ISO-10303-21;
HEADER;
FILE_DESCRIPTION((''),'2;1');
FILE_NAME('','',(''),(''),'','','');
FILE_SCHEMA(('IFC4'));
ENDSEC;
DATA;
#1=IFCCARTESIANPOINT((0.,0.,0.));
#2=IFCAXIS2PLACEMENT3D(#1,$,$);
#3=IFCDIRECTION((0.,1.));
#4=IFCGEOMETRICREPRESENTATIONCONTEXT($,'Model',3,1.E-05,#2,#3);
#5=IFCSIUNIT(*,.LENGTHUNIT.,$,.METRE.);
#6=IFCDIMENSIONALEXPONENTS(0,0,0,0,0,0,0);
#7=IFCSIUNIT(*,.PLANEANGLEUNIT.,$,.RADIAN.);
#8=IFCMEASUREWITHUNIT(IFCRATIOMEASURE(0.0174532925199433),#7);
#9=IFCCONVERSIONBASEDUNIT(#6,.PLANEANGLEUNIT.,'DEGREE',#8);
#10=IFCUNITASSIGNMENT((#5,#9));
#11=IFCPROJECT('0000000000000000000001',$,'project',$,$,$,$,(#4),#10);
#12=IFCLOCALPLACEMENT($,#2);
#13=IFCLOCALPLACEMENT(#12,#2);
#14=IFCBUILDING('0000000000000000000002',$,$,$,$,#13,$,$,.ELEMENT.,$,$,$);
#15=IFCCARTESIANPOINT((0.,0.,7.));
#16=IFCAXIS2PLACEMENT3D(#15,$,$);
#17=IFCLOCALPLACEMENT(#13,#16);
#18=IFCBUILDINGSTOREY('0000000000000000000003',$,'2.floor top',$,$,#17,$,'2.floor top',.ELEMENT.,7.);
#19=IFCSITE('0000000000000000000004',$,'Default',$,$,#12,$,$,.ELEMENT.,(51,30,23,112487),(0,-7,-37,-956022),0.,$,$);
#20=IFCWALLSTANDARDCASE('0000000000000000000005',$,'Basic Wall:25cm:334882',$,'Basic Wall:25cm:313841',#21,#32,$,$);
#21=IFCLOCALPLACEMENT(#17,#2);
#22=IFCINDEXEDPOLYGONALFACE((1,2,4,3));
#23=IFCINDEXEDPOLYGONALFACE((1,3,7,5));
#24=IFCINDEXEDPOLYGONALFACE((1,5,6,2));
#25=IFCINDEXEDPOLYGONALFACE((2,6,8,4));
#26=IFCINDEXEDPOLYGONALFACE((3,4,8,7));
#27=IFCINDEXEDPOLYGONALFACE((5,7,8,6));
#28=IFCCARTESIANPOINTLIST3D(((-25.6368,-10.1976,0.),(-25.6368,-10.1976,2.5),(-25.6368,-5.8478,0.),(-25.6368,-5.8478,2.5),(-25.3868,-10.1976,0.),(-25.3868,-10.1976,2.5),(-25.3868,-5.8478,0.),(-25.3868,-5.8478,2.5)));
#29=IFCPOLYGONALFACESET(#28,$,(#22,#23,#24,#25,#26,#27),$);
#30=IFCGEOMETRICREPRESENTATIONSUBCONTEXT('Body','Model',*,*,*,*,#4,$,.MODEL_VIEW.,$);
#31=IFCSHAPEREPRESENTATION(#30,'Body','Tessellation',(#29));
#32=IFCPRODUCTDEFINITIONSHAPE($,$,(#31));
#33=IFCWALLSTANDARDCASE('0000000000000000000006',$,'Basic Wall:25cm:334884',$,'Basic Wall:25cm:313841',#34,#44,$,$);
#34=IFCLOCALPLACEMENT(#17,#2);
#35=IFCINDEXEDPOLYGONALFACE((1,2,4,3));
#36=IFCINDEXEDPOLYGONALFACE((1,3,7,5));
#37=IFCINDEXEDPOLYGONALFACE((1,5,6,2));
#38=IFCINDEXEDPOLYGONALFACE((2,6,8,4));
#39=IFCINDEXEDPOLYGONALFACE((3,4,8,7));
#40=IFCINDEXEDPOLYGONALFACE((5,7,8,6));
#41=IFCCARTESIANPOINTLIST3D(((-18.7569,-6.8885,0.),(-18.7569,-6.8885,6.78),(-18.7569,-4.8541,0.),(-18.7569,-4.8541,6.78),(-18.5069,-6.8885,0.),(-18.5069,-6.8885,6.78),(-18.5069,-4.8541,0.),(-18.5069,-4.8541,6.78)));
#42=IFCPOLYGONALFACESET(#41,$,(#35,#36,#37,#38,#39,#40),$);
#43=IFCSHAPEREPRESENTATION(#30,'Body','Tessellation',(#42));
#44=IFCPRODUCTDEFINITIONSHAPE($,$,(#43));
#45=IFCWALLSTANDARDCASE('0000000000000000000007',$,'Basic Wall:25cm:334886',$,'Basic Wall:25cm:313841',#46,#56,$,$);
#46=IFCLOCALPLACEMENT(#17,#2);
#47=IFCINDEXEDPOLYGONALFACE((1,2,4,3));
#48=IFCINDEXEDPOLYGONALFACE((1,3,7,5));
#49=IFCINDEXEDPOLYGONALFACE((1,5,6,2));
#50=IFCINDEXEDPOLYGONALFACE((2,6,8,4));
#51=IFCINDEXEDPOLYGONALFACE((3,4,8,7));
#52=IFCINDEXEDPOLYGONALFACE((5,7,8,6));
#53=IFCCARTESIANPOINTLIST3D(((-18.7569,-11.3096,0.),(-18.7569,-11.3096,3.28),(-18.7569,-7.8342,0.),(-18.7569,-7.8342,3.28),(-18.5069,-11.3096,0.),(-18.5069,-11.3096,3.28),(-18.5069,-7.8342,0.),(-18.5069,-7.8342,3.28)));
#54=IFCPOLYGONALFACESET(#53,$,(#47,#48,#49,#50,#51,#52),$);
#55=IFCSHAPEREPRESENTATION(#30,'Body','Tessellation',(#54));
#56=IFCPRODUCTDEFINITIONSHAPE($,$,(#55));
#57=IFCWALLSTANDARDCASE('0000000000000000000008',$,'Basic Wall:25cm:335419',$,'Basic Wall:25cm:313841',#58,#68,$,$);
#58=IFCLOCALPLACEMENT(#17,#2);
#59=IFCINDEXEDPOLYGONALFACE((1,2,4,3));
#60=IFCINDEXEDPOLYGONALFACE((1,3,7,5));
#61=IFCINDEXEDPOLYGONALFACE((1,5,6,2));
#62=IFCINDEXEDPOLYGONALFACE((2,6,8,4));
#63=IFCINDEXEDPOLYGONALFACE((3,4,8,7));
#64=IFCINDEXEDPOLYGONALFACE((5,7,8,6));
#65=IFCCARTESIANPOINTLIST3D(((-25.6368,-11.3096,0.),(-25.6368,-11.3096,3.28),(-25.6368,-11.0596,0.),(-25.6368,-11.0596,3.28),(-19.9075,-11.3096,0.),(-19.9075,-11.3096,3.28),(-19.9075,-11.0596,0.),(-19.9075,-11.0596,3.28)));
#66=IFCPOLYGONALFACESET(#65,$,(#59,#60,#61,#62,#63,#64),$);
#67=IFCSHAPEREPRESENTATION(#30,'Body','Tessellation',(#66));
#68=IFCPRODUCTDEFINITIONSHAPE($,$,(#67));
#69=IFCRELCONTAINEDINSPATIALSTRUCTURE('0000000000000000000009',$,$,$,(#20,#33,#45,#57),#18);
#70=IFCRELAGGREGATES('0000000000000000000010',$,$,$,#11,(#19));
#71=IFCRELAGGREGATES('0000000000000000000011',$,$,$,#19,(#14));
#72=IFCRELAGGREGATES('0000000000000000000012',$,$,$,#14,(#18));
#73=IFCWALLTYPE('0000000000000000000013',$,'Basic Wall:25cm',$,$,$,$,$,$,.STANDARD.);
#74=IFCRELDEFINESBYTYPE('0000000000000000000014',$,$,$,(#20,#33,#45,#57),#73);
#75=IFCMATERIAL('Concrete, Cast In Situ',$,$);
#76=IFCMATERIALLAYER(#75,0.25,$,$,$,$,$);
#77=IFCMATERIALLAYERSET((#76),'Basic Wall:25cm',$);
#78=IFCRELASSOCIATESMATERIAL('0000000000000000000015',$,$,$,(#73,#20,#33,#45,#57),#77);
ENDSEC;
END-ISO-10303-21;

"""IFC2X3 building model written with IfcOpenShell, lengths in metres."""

from ifc_helpers import new_model, entity, si_unit, converted_unit, direction, frame, frame_2d, origin, place, context, subcontext, project, spatial, rectangle, extrude, material, layer, layer_set, layer_usage, type_object, element, save


model = new_model("IFC2X3")

# Units and contexts
model_context = context("Model", 3, precision=1e-05, world=origin(), true_north=direction((0.0, 1.0)))
body_context = subcontext(model_context, "Body", "Model", "MODEL_VIEW")
ifc_project = project(units=[si_unit("LENGTHUNIT", "METRE"), converted_unit("PLANEANGLEUNIT", "DEGREE", entity("IfcRatioMeasure", 0.0174532925199433), si_unit("PLANEANGLEUNIT", "RADIAN"), dimensions=[0, 0, 0, 0, 0, 0, 0])], contexts=[model_context])

# Site, building, storey
site_placement = place(None, origin())
site = spatial("IfcSite", under=ifc_project, at=site_placement, Name="Default", CompositionType="ELEMENT", RefLatitude=(51, 30, 23, 112487), RefLongitude=(0, -7, -37, -956022), RefElevation=0.0)
building_placement = place(site_placement, origin())
building = spatial("IfcBuilding", under=site, at=building_placement, CompositionType="ELEMENT")
storey_placement = place(building_placement, frame((0.0, 0.0, 7.0)))
storey = spatial("IfcBuildingStorey", under=building, at=storey_placement, Name="2.floor top", LongName="2.floor top", CompositionType="ELEMENT", Elevation=7.0)

# Shared definitions
ifc_material = material(Name="Concrete, Cast In Situ")
ifc_layer = layer(ifc_material, 0.25)
ifc_layer_set = layer_set([ifc_layer], Name="Basic Wall:25cm")
wall_type = type_object("IfcWallType", Name="Basic Wall:25cm", PredefinedType="STANDARD", material=ifc_layer_set)

# Walls
ifc_layer_usage_1 = layer_usage(ifc_layer_set, "AXIS2", "NEGATIVE", 0.125)
wall_1_placement = place(storey_placement, frame((-25.5118, -5.8478, 0.0), z_axis=(0.0, 0.0, 1.0), x_axis=(0.0, -1.0, 0.0)))
element("IfcWallStandardCase", 1, at=wall_1_placement, inside=storey, type_object=wall_type, material=ifc_layer_usage_1, Name="Basic Wall:25cm:334882", ObjectType="Basic Wall:25cm:313841", context=body_context, shape_type="SweptSolid", body=[
    extrude(rectangle(XDim=4.3498, YDim=0.25, at=frame_2d((2.1749, 0.0), x_axis=(-1.0, 0.0))), origin(), (0.0, 0.0, 1.0), 2.5),
])
ifc_layer_usage_2 = layer_usage(ifc_layer_set, "AXIS2", "NEGATIVE", 0.125)
wall_2_placement = place(storey_placement, frame((-18.6319, -6.8885, 0.0), z_axis=(0.0, 0.0, 1.0), x_axis=(0.0, 1.0, 0.0)))
element("IfcWallStandardCase", 2, at=wall_2_placement, inside=storey, type_object=wall_type, material=ifc_layer_usage_2, Name="Basic Wall:25cm:334884", ObjectType="Basic Wall:25cm:313841", context=body_context, shape_type="SweptSolid", body=[
    extrude(rectangle(XDim=2.0344, YDim=0.25, at=frame_2d((1.0172, 0.0), x_axis=(-1.0, 0.0))), origin(), (0.0, 0.0, 1.0), 6.78),
])
ifc_layer_usage_3 = layer_usage(ifc_layer_set, "AXIS2", "POSITIVE", -0.125)
wall_3_placement = place(storey_placement, frame((-18.6319, -7.8342, 0.0), z_axis=(0.0, 0.0, 1.0), x_axis=(0.0, -1.0, 0.0)))
element("IfcWallStandardCase", 3, at=wall_3_placement, inside=storey, type_object=wall_type, material=ifc_layer_usage_3, Name="Basic Wall:25cm:334886", ObjectType="Basic Wall:25cm:313841", context=body_context, shape_type="SweptSolid", body=[
    extrude(rectangle(XDim=3.4754, YDim=0.25, at=frame_2d((1.7377, 0.0), x_axis=(-1.0, 0.0))), origin(), (0.0, 0.0, 1.0), 3.28),
])
ifc_layer_usage_4 = layer_usage(ifc_layer_set, "AXIS2", "NEGATIVE", 0.125)
wall_4_placement = place(storey_placement, frame((-25.6368, -11.1846, 0.0)))
element("IfcWallStandardCase", 4, at=wall_4_placement, inside=storey, type_object=wall_type, material=ifc_layer_usage_4, Name="Basic Wall:25cm:335419", ObjectType="Basic Wall:25cm:313841", context=body_context, shape_type="SweptSolid", body=[
    extrude(rectangle(XDim=5.7293, YDim=0.25, at=frame_2d((2.8646, 0.0), x_axis=(-1.0, 0.0))), origin(), (0.0, 0.0, 1.0), 3.28),
])

save(model, "model.ifc")
